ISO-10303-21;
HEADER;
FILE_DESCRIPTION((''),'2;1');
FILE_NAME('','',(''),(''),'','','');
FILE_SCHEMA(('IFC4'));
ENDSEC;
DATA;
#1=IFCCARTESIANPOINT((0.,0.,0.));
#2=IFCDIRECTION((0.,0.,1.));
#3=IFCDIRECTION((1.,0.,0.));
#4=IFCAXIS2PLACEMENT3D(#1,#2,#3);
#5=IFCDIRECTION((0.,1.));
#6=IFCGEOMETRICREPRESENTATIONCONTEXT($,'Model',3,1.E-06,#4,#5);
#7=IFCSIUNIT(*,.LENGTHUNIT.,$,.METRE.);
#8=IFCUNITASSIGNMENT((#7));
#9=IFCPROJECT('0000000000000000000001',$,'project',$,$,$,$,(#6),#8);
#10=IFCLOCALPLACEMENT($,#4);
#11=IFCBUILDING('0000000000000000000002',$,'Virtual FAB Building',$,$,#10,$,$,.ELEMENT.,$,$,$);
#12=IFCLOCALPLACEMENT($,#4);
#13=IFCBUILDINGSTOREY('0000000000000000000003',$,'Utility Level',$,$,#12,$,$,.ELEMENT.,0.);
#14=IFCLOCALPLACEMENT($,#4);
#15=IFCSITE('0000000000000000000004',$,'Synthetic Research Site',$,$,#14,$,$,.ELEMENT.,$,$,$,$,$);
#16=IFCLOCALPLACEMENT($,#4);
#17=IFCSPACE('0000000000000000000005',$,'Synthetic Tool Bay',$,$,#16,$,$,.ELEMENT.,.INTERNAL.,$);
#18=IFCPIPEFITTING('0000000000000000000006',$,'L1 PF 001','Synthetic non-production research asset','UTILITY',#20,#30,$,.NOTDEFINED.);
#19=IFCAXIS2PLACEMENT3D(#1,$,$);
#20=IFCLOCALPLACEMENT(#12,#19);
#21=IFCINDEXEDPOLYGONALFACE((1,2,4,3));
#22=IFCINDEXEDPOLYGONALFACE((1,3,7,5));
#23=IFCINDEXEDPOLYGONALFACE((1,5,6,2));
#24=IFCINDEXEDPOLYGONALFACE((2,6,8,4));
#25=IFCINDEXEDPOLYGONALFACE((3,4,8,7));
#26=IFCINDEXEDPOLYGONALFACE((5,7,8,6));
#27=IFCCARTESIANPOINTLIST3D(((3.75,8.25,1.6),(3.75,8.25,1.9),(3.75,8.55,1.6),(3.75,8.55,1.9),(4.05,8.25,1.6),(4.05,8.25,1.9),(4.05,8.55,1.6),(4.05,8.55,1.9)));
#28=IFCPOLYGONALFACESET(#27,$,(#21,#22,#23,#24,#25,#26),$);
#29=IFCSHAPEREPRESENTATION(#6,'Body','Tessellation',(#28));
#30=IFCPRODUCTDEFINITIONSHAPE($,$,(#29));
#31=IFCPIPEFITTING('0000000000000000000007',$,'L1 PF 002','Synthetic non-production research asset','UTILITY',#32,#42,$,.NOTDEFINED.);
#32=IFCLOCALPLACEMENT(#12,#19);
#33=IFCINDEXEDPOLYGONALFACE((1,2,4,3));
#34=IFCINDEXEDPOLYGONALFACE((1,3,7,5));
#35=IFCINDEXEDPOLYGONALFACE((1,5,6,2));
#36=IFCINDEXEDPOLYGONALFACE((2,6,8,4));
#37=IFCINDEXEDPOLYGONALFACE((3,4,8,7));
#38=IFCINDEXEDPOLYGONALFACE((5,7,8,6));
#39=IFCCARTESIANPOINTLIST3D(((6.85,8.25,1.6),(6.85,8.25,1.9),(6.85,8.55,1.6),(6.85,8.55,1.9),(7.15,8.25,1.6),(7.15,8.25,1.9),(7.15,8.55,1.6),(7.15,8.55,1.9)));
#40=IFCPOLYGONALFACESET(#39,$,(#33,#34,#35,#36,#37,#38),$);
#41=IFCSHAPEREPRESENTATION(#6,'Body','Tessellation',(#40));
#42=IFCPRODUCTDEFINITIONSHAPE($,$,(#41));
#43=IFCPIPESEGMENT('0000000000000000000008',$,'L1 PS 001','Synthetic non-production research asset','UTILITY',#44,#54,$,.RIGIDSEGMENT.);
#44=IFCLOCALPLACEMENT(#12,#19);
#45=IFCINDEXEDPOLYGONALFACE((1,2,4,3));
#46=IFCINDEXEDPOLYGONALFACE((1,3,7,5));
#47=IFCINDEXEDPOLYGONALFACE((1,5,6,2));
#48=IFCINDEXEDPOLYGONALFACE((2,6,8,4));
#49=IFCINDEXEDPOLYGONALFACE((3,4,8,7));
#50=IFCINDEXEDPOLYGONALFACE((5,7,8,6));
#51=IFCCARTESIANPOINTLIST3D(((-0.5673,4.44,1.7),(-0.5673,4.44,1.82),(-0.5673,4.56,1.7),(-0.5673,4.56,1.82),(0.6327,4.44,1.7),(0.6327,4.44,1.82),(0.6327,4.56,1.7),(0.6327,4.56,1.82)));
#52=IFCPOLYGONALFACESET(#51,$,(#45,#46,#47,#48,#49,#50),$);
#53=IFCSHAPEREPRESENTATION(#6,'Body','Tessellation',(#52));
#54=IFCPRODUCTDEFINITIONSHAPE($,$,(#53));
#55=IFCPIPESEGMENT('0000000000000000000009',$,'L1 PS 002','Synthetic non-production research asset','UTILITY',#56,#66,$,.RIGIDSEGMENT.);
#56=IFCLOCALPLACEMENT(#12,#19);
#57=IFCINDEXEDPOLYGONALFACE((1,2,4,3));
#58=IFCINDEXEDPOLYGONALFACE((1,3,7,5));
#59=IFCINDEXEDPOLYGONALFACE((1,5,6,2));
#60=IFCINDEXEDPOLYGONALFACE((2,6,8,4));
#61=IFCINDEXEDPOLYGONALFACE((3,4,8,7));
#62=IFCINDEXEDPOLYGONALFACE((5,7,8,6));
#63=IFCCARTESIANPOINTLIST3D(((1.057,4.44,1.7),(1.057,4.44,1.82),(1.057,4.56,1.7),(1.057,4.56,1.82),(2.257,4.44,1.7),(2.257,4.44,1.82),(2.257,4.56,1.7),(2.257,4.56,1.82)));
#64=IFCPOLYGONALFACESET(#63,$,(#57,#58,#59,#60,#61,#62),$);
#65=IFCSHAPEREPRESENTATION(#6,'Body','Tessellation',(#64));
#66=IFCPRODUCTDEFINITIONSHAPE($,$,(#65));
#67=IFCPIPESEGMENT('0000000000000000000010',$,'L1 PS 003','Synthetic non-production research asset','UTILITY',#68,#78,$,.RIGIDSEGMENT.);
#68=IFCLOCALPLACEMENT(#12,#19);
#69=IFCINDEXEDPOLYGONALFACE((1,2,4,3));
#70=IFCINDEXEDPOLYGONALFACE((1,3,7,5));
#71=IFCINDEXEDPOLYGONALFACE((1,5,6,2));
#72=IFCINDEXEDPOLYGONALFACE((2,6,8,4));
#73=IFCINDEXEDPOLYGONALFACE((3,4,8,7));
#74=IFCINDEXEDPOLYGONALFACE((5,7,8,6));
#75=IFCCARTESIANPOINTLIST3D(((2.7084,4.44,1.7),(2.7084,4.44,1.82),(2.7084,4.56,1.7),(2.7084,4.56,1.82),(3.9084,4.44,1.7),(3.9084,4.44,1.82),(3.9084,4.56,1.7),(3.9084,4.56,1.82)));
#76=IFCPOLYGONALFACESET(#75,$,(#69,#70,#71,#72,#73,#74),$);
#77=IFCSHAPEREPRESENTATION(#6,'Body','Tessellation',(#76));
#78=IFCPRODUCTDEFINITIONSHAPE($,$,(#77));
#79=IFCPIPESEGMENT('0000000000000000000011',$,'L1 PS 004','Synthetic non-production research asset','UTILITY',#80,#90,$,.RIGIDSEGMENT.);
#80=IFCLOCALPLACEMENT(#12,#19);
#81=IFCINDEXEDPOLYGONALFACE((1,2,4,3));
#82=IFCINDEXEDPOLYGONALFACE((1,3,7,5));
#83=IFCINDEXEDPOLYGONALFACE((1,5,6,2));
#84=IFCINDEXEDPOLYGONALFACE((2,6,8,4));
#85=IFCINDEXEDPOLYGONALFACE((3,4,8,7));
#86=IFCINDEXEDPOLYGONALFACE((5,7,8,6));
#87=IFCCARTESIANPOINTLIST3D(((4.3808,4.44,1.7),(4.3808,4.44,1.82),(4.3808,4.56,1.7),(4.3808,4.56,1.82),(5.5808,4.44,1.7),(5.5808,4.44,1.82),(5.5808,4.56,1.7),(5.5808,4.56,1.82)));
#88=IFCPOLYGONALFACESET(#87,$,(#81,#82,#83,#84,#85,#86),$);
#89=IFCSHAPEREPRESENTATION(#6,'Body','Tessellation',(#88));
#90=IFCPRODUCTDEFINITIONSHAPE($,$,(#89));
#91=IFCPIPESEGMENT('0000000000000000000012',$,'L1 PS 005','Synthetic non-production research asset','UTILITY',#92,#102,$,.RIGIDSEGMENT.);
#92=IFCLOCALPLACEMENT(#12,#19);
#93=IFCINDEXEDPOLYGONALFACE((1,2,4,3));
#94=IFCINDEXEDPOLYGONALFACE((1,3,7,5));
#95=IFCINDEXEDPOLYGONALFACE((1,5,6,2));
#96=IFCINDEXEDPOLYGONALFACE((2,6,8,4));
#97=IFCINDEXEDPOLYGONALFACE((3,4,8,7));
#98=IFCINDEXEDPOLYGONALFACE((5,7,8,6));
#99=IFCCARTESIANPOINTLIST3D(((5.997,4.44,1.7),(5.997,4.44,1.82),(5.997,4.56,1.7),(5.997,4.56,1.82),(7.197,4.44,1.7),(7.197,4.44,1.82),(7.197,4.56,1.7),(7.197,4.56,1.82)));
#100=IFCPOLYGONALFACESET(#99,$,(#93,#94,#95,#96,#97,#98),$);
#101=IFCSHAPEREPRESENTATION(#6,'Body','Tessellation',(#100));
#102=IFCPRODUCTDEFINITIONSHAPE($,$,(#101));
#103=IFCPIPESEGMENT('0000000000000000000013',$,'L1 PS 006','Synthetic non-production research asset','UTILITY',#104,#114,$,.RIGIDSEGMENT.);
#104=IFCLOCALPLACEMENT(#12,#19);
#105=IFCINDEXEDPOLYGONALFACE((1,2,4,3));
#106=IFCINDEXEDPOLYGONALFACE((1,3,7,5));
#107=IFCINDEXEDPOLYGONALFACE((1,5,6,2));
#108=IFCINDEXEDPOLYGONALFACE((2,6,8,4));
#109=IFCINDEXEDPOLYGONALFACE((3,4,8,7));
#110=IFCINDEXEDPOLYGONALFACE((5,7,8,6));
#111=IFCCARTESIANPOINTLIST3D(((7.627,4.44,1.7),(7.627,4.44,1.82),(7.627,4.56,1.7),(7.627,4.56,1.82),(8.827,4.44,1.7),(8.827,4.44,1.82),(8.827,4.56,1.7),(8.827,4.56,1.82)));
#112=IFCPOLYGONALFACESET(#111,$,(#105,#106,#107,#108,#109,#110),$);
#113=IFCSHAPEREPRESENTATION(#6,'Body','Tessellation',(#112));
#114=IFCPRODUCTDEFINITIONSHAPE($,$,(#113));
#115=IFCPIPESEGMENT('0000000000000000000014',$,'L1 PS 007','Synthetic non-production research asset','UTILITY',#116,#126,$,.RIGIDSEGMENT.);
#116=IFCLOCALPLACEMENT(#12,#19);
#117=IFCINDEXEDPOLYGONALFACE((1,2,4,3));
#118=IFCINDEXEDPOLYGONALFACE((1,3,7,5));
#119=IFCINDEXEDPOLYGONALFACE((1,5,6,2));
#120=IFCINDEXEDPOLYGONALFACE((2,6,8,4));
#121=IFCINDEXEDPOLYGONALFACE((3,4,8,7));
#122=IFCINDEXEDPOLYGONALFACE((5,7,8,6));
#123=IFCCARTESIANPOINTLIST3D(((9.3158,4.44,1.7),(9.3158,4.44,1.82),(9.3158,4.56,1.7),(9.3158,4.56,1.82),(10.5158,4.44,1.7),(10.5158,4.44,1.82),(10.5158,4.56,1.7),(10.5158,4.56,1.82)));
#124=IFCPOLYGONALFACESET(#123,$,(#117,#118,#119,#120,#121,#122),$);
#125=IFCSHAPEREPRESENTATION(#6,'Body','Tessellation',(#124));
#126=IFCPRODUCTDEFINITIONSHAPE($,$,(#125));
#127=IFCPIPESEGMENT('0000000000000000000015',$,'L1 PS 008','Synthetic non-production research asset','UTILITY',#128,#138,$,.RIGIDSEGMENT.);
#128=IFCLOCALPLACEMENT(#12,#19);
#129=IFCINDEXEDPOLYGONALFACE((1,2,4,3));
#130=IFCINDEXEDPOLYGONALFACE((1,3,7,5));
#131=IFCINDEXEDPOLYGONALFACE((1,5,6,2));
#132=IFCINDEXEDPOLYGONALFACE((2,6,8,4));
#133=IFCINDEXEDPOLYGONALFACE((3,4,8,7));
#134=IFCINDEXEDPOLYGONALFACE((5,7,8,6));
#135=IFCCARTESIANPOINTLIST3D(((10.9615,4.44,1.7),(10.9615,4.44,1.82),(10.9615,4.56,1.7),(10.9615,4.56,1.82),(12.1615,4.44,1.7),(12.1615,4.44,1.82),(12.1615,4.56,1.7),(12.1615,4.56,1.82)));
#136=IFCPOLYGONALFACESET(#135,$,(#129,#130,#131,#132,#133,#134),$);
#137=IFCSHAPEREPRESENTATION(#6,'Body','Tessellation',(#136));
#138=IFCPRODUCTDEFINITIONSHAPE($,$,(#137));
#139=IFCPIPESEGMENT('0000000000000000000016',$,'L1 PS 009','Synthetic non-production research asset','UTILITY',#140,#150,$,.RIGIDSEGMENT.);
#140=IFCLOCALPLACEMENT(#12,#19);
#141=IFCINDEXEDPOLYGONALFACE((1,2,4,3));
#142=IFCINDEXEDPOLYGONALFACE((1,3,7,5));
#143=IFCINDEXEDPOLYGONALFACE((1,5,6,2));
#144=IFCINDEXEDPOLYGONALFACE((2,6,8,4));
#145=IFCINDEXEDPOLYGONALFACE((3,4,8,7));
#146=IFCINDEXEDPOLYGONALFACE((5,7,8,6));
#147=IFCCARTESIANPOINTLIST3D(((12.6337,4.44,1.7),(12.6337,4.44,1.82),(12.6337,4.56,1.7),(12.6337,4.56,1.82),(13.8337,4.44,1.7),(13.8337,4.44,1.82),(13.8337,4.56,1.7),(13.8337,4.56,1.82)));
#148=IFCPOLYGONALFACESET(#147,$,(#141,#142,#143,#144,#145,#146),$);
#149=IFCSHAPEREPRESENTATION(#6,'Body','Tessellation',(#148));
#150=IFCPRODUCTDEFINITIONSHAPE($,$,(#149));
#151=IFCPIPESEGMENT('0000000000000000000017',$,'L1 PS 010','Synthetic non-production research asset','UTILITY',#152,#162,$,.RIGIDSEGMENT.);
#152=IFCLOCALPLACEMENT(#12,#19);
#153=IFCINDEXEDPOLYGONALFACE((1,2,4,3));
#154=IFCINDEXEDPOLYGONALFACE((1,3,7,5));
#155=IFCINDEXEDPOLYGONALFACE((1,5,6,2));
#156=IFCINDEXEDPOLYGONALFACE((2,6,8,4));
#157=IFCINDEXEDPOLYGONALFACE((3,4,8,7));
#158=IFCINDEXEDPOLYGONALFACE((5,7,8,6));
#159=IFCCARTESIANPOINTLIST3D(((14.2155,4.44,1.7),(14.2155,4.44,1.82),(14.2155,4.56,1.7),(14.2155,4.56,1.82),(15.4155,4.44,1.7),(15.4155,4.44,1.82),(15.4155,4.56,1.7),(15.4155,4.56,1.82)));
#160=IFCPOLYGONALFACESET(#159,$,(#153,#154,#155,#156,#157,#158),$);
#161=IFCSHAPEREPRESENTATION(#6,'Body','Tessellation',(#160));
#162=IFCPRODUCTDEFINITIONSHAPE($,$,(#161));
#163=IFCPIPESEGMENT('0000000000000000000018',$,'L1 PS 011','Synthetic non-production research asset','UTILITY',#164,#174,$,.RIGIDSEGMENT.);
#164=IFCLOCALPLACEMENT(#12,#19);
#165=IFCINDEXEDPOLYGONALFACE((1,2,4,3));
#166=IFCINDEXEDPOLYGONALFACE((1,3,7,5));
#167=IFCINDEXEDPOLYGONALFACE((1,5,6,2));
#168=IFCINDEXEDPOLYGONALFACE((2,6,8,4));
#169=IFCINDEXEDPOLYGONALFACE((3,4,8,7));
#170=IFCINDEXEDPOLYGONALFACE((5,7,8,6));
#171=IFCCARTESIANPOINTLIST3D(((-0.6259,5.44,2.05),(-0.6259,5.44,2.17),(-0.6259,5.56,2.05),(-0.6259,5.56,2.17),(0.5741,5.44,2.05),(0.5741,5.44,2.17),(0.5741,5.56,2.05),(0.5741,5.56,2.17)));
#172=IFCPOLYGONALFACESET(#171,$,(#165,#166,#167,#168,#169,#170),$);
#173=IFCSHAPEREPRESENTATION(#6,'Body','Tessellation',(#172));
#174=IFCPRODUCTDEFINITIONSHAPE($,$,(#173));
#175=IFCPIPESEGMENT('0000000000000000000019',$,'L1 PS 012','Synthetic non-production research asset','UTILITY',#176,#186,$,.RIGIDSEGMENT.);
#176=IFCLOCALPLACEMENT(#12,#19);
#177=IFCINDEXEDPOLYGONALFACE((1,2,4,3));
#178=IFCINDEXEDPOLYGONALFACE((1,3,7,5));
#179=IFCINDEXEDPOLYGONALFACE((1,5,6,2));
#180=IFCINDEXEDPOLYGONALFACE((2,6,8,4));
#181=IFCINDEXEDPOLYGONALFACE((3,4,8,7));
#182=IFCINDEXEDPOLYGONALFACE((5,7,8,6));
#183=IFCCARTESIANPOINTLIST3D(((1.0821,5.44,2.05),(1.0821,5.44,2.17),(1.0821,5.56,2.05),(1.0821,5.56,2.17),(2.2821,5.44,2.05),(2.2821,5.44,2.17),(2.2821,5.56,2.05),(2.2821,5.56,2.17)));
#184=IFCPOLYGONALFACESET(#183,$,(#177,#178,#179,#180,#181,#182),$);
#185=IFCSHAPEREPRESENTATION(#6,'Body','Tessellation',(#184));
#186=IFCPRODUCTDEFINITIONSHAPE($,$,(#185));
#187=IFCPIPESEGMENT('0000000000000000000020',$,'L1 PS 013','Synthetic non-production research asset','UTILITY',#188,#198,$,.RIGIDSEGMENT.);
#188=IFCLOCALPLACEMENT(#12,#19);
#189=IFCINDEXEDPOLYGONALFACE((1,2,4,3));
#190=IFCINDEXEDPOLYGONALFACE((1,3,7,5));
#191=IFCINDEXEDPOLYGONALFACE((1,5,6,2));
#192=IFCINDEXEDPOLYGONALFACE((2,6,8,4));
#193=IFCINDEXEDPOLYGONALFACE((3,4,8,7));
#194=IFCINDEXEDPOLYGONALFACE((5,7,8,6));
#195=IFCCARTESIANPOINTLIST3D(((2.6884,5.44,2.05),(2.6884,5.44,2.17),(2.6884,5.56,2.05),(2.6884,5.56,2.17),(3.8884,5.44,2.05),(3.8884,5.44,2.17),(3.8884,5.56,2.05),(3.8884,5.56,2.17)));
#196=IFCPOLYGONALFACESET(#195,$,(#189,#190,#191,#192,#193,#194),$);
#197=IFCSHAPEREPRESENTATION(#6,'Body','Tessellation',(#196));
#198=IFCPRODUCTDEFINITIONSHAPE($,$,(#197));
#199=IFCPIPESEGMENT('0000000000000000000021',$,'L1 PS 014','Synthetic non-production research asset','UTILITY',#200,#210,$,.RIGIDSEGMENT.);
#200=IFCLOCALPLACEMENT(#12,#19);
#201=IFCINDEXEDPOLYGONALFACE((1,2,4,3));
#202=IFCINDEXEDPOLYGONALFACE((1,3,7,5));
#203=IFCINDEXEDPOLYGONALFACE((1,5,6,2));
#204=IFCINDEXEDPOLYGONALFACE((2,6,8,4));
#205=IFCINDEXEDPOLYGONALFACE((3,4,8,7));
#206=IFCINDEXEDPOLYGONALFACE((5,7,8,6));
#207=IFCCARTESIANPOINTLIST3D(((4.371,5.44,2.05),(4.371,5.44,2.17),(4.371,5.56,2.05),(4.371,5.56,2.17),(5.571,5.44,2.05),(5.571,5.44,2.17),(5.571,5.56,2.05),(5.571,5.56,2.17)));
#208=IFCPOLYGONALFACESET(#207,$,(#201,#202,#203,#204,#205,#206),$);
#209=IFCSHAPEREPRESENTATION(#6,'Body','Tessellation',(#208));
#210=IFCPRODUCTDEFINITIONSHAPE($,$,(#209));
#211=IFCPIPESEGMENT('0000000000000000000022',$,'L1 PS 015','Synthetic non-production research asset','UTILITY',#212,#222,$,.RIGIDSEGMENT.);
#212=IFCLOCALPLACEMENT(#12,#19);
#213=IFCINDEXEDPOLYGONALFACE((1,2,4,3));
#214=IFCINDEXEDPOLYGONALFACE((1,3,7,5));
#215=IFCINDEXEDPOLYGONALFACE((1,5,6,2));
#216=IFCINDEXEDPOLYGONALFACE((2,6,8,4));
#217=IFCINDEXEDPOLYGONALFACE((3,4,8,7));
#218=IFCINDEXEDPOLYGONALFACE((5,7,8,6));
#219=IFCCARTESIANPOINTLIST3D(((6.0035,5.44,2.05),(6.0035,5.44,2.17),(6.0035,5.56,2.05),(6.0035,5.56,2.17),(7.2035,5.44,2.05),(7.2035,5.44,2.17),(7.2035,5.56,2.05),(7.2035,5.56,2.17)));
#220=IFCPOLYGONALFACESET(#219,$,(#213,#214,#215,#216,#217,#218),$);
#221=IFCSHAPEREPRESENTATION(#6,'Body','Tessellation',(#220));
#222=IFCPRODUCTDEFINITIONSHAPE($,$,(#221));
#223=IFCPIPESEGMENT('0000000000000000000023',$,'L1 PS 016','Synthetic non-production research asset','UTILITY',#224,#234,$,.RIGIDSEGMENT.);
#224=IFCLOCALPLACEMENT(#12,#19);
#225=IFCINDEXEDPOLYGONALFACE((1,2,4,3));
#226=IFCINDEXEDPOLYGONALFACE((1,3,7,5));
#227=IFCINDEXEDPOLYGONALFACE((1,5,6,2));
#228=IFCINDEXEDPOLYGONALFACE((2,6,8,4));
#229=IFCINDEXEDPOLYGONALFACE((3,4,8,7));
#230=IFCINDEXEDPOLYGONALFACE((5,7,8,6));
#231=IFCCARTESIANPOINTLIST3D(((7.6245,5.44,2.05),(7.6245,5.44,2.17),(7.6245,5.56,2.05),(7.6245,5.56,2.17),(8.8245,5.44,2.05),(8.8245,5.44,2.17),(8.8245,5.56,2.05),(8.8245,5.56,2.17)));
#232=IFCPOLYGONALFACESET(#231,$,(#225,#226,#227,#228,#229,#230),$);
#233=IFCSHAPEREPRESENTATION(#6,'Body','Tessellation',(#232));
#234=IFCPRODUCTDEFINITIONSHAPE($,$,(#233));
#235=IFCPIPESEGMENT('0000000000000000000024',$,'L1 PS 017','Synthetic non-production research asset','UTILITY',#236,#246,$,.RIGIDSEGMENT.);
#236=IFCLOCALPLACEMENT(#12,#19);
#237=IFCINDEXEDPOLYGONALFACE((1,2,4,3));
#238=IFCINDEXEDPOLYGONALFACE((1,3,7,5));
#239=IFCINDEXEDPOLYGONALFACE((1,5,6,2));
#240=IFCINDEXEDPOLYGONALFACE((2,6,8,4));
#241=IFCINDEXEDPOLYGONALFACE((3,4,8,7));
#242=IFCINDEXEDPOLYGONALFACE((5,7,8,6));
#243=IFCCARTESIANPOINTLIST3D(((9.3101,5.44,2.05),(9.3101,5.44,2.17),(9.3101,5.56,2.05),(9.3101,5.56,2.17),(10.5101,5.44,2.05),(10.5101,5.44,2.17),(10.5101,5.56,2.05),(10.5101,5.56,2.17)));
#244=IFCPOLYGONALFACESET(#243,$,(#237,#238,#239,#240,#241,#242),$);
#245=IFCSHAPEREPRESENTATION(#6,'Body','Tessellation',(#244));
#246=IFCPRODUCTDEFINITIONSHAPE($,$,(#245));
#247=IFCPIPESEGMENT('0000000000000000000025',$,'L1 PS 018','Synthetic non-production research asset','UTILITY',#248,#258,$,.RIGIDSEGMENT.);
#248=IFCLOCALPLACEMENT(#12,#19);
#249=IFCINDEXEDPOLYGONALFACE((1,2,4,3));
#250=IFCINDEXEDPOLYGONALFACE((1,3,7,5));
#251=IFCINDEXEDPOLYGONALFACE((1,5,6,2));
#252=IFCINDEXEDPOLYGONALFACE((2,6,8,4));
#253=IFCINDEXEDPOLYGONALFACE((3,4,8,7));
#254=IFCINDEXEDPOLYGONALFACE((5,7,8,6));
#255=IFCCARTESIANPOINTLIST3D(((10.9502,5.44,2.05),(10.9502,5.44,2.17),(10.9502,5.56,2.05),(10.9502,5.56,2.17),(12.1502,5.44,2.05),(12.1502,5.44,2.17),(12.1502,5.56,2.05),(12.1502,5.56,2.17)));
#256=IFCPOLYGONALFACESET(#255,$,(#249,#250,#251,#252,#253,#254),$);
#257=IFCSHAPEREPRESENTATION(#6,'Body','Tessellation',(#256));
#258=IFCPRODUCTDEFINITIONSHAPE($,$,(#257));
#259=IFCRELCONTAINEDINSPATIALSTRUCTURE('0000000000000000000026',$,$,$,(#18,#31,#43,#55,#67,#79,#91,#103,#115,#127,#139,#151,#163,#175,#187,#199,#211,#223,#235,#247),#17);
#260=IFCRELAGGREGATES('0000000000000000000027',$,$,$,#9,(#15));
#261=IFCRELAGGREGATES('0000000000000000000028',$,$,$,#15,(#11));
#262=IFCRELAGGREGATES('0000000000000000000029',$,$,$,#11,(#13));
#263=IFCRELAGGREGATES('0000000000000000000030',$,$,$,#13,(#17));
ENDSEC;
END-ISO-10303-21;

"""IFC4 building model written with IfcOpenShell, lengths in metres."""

from ifc_helpers import new_model, si_unit, direction, frame, origin_with_axes, origin_2d_with_axis, place, context, project, spatial, rectangle, extrude, element, save


model = new_model("IFC4")

# Units and contexts
model_context = context("Model", 3, precision=1e-06, world=origin_with_axes(), true_north=direction((0.0, 1.0)))
ifc_project = project(units=[si_unit("LENGTHUNIT", "METRE")], contexts=[model_context])

# Site, building, storey, space
site_placement = place(None, origin_with_axes())
site = spatial("IfcSite", under=ifc_project, at=site_placement, Name="Synthetic Research Site", CompositionType="ELEMENT")
building_placement = place(None, origin_with_axes())
building = spatial("IfcBuilding", under=site, at=building_placement, Name="Virtual FAB Building", CompositionType="ELEMENT")
storey_placement = place(None, origin_with_axes())
storey = spatial("IfcBuildingStorey", under=building, at=storey_placement, Name="Utility Level", CompositionType="ELEMENT", Elevation=0.0)
space_placement = place(None, origin_with_axes())
space = spatial("IfcSpace", under=storey, at=space_placement, Name="Synthetic Tool Bay", CompositionType="ELEMENT", PredefinedType="INTERNAL")

# Pipe fittings
for number, where, z_axis, x_axis, name in (
    (1, (3.9, 8.4, 1.6), (0.0, 0.0, 1.0), (1.0, 0.0, 0.0), "L1 PF 001"),
    (2, (7.0, 8.4, 1.6), (0.0, 0.0, 1.0), (1.0, 0.0, 0.0), "L1 PF 002"),
):
    element("IfcPipeFitting", number, at=place(None, frame(where, z_axis=z_axis, x_axis=x_axis)), inside=space, Name=name, Description="Synthetic non-production research asset", ObjectType="UTILITY", PredefinedType="NOTDEFINED", context=model_context, shape_type="SweptSolid", body=[
        extrude(rectangle(XDim=0.3, YDim=0.3, at=origin_2d_with_axis()), origin_with_axes(), (0.0, 0.0, 1.0), 0.3),
    ])

# Pipe segments
for number, where, z_axis, x_axis, name in (
    (3, (0.0327, 4.5, 1.7), (0.0, 0.0, 1.0), (1.0, 0.0, 0.0), "L1 PS 001"),
    (4, (1.657, 4.5, 1.7), (0.0, 0.0, 1.0), (1.0, 0.0, 0.0), "L1 PS 002"),
    (5, (3.3084, 4.5, 1.7), (0.0, 0.0, 1.0), (1.0, 0.0, 0.0), "L1 PS 003"),
    (6, (4.9808, 4.5, 1.7), (0.0, 0.0, 1.0), (1.0, 0.0, 0.0), "L1 PS 004"),
    (7, (6.597, 4.5, 1.7), (0.0, 0.0, 1.0), (1.0, 0.0, 0.0), "L1 PS 005"),
    (8, (8.227, 4.5, 1.7), (0.0, 0.0, 1.0), (1.0, 0.0, 0.0), "L1 PS 006"),
    (9, (9.9158, 4.5, 1.7), (0.0, 0.0, 1.0), (1.0, 0.0, 0.0), "L1 PS 007"),
    (10, (11.5615, 4.5, 1.7), (0.0, 0.0, 1.0), (1.0, 0.0, 0.0), "L1 PS 008"),
    (11, (13.2337, 4.5, 1.7), (0.0, 0.0, 1.0), (1.0, 0.0, 0.0), "L1 PS 009"),
    (12, (14.8155, 4.5, 1.7), (0.0, 0.0, 1.0), (1.0, 0.0, 0.0), "L1 PS 010"),
    (13, (-0.0259, 5.5, 2.05), (0.0, 0.0, 1.0), (1.0, 0.0, 0.0), "L1 PS 011"),
    (14, (1.6821, 5.5, 2.05), (0.0, 0.0, 1.0), (1.0, 0.0, 0.0), "L1 PS 012"),
    (15, (3.2884, 5.5, 2.05), (0.0, 0.0, 1.0), (1.0, 0.0, 0.0), "L1 PS 013"),
    (16, (4.971, 5.5, 2.05), (0.0, 0.0, 1.0), (1.0, 0.0, 0.0), "L1 PS 014"),
    (17, (6.6035, 5.5, 2.05), (0.0, 0.0, 1.0), (1.0, 0.0, 0.0), "L1 PS 015"),
    (18, (8.2245, 5.5, 2.05), (0.0, 0.0, 1.0), (1.0, 0.0, 0.0), "L1 PS 016"),
    (19, (9.9101, 5.5, 2.05), (0.0, 0.0, 1.0), (1.0, 0.0, 0.0), "L1 PS 017"),
    (20, (11.5502, 5.5, 2.05), (0.0, 0.0, 1.0), (1.0, 0.0, 0.0), "L1 PS 018"),
):
    element("IfcPipeSegment", number, at=place(None, frame(where, z_axis=z_axis, x_axis=x_axis)), inside=space, Name=name, Description="Synthetic non-production research asset", ObjectType="UTILITY", PredefinedType="RIGIDSEGMENT", context=model_context, shape_type="SweptSolid", body=[
        extrude(rectangle(XDim=1.2, YDim=0.12, at=origin_2d_with_axis()), origin_with_axes(), (0.0, 0.0, 1.0), 0.12),
    ])

save(model, "model.ifc")
